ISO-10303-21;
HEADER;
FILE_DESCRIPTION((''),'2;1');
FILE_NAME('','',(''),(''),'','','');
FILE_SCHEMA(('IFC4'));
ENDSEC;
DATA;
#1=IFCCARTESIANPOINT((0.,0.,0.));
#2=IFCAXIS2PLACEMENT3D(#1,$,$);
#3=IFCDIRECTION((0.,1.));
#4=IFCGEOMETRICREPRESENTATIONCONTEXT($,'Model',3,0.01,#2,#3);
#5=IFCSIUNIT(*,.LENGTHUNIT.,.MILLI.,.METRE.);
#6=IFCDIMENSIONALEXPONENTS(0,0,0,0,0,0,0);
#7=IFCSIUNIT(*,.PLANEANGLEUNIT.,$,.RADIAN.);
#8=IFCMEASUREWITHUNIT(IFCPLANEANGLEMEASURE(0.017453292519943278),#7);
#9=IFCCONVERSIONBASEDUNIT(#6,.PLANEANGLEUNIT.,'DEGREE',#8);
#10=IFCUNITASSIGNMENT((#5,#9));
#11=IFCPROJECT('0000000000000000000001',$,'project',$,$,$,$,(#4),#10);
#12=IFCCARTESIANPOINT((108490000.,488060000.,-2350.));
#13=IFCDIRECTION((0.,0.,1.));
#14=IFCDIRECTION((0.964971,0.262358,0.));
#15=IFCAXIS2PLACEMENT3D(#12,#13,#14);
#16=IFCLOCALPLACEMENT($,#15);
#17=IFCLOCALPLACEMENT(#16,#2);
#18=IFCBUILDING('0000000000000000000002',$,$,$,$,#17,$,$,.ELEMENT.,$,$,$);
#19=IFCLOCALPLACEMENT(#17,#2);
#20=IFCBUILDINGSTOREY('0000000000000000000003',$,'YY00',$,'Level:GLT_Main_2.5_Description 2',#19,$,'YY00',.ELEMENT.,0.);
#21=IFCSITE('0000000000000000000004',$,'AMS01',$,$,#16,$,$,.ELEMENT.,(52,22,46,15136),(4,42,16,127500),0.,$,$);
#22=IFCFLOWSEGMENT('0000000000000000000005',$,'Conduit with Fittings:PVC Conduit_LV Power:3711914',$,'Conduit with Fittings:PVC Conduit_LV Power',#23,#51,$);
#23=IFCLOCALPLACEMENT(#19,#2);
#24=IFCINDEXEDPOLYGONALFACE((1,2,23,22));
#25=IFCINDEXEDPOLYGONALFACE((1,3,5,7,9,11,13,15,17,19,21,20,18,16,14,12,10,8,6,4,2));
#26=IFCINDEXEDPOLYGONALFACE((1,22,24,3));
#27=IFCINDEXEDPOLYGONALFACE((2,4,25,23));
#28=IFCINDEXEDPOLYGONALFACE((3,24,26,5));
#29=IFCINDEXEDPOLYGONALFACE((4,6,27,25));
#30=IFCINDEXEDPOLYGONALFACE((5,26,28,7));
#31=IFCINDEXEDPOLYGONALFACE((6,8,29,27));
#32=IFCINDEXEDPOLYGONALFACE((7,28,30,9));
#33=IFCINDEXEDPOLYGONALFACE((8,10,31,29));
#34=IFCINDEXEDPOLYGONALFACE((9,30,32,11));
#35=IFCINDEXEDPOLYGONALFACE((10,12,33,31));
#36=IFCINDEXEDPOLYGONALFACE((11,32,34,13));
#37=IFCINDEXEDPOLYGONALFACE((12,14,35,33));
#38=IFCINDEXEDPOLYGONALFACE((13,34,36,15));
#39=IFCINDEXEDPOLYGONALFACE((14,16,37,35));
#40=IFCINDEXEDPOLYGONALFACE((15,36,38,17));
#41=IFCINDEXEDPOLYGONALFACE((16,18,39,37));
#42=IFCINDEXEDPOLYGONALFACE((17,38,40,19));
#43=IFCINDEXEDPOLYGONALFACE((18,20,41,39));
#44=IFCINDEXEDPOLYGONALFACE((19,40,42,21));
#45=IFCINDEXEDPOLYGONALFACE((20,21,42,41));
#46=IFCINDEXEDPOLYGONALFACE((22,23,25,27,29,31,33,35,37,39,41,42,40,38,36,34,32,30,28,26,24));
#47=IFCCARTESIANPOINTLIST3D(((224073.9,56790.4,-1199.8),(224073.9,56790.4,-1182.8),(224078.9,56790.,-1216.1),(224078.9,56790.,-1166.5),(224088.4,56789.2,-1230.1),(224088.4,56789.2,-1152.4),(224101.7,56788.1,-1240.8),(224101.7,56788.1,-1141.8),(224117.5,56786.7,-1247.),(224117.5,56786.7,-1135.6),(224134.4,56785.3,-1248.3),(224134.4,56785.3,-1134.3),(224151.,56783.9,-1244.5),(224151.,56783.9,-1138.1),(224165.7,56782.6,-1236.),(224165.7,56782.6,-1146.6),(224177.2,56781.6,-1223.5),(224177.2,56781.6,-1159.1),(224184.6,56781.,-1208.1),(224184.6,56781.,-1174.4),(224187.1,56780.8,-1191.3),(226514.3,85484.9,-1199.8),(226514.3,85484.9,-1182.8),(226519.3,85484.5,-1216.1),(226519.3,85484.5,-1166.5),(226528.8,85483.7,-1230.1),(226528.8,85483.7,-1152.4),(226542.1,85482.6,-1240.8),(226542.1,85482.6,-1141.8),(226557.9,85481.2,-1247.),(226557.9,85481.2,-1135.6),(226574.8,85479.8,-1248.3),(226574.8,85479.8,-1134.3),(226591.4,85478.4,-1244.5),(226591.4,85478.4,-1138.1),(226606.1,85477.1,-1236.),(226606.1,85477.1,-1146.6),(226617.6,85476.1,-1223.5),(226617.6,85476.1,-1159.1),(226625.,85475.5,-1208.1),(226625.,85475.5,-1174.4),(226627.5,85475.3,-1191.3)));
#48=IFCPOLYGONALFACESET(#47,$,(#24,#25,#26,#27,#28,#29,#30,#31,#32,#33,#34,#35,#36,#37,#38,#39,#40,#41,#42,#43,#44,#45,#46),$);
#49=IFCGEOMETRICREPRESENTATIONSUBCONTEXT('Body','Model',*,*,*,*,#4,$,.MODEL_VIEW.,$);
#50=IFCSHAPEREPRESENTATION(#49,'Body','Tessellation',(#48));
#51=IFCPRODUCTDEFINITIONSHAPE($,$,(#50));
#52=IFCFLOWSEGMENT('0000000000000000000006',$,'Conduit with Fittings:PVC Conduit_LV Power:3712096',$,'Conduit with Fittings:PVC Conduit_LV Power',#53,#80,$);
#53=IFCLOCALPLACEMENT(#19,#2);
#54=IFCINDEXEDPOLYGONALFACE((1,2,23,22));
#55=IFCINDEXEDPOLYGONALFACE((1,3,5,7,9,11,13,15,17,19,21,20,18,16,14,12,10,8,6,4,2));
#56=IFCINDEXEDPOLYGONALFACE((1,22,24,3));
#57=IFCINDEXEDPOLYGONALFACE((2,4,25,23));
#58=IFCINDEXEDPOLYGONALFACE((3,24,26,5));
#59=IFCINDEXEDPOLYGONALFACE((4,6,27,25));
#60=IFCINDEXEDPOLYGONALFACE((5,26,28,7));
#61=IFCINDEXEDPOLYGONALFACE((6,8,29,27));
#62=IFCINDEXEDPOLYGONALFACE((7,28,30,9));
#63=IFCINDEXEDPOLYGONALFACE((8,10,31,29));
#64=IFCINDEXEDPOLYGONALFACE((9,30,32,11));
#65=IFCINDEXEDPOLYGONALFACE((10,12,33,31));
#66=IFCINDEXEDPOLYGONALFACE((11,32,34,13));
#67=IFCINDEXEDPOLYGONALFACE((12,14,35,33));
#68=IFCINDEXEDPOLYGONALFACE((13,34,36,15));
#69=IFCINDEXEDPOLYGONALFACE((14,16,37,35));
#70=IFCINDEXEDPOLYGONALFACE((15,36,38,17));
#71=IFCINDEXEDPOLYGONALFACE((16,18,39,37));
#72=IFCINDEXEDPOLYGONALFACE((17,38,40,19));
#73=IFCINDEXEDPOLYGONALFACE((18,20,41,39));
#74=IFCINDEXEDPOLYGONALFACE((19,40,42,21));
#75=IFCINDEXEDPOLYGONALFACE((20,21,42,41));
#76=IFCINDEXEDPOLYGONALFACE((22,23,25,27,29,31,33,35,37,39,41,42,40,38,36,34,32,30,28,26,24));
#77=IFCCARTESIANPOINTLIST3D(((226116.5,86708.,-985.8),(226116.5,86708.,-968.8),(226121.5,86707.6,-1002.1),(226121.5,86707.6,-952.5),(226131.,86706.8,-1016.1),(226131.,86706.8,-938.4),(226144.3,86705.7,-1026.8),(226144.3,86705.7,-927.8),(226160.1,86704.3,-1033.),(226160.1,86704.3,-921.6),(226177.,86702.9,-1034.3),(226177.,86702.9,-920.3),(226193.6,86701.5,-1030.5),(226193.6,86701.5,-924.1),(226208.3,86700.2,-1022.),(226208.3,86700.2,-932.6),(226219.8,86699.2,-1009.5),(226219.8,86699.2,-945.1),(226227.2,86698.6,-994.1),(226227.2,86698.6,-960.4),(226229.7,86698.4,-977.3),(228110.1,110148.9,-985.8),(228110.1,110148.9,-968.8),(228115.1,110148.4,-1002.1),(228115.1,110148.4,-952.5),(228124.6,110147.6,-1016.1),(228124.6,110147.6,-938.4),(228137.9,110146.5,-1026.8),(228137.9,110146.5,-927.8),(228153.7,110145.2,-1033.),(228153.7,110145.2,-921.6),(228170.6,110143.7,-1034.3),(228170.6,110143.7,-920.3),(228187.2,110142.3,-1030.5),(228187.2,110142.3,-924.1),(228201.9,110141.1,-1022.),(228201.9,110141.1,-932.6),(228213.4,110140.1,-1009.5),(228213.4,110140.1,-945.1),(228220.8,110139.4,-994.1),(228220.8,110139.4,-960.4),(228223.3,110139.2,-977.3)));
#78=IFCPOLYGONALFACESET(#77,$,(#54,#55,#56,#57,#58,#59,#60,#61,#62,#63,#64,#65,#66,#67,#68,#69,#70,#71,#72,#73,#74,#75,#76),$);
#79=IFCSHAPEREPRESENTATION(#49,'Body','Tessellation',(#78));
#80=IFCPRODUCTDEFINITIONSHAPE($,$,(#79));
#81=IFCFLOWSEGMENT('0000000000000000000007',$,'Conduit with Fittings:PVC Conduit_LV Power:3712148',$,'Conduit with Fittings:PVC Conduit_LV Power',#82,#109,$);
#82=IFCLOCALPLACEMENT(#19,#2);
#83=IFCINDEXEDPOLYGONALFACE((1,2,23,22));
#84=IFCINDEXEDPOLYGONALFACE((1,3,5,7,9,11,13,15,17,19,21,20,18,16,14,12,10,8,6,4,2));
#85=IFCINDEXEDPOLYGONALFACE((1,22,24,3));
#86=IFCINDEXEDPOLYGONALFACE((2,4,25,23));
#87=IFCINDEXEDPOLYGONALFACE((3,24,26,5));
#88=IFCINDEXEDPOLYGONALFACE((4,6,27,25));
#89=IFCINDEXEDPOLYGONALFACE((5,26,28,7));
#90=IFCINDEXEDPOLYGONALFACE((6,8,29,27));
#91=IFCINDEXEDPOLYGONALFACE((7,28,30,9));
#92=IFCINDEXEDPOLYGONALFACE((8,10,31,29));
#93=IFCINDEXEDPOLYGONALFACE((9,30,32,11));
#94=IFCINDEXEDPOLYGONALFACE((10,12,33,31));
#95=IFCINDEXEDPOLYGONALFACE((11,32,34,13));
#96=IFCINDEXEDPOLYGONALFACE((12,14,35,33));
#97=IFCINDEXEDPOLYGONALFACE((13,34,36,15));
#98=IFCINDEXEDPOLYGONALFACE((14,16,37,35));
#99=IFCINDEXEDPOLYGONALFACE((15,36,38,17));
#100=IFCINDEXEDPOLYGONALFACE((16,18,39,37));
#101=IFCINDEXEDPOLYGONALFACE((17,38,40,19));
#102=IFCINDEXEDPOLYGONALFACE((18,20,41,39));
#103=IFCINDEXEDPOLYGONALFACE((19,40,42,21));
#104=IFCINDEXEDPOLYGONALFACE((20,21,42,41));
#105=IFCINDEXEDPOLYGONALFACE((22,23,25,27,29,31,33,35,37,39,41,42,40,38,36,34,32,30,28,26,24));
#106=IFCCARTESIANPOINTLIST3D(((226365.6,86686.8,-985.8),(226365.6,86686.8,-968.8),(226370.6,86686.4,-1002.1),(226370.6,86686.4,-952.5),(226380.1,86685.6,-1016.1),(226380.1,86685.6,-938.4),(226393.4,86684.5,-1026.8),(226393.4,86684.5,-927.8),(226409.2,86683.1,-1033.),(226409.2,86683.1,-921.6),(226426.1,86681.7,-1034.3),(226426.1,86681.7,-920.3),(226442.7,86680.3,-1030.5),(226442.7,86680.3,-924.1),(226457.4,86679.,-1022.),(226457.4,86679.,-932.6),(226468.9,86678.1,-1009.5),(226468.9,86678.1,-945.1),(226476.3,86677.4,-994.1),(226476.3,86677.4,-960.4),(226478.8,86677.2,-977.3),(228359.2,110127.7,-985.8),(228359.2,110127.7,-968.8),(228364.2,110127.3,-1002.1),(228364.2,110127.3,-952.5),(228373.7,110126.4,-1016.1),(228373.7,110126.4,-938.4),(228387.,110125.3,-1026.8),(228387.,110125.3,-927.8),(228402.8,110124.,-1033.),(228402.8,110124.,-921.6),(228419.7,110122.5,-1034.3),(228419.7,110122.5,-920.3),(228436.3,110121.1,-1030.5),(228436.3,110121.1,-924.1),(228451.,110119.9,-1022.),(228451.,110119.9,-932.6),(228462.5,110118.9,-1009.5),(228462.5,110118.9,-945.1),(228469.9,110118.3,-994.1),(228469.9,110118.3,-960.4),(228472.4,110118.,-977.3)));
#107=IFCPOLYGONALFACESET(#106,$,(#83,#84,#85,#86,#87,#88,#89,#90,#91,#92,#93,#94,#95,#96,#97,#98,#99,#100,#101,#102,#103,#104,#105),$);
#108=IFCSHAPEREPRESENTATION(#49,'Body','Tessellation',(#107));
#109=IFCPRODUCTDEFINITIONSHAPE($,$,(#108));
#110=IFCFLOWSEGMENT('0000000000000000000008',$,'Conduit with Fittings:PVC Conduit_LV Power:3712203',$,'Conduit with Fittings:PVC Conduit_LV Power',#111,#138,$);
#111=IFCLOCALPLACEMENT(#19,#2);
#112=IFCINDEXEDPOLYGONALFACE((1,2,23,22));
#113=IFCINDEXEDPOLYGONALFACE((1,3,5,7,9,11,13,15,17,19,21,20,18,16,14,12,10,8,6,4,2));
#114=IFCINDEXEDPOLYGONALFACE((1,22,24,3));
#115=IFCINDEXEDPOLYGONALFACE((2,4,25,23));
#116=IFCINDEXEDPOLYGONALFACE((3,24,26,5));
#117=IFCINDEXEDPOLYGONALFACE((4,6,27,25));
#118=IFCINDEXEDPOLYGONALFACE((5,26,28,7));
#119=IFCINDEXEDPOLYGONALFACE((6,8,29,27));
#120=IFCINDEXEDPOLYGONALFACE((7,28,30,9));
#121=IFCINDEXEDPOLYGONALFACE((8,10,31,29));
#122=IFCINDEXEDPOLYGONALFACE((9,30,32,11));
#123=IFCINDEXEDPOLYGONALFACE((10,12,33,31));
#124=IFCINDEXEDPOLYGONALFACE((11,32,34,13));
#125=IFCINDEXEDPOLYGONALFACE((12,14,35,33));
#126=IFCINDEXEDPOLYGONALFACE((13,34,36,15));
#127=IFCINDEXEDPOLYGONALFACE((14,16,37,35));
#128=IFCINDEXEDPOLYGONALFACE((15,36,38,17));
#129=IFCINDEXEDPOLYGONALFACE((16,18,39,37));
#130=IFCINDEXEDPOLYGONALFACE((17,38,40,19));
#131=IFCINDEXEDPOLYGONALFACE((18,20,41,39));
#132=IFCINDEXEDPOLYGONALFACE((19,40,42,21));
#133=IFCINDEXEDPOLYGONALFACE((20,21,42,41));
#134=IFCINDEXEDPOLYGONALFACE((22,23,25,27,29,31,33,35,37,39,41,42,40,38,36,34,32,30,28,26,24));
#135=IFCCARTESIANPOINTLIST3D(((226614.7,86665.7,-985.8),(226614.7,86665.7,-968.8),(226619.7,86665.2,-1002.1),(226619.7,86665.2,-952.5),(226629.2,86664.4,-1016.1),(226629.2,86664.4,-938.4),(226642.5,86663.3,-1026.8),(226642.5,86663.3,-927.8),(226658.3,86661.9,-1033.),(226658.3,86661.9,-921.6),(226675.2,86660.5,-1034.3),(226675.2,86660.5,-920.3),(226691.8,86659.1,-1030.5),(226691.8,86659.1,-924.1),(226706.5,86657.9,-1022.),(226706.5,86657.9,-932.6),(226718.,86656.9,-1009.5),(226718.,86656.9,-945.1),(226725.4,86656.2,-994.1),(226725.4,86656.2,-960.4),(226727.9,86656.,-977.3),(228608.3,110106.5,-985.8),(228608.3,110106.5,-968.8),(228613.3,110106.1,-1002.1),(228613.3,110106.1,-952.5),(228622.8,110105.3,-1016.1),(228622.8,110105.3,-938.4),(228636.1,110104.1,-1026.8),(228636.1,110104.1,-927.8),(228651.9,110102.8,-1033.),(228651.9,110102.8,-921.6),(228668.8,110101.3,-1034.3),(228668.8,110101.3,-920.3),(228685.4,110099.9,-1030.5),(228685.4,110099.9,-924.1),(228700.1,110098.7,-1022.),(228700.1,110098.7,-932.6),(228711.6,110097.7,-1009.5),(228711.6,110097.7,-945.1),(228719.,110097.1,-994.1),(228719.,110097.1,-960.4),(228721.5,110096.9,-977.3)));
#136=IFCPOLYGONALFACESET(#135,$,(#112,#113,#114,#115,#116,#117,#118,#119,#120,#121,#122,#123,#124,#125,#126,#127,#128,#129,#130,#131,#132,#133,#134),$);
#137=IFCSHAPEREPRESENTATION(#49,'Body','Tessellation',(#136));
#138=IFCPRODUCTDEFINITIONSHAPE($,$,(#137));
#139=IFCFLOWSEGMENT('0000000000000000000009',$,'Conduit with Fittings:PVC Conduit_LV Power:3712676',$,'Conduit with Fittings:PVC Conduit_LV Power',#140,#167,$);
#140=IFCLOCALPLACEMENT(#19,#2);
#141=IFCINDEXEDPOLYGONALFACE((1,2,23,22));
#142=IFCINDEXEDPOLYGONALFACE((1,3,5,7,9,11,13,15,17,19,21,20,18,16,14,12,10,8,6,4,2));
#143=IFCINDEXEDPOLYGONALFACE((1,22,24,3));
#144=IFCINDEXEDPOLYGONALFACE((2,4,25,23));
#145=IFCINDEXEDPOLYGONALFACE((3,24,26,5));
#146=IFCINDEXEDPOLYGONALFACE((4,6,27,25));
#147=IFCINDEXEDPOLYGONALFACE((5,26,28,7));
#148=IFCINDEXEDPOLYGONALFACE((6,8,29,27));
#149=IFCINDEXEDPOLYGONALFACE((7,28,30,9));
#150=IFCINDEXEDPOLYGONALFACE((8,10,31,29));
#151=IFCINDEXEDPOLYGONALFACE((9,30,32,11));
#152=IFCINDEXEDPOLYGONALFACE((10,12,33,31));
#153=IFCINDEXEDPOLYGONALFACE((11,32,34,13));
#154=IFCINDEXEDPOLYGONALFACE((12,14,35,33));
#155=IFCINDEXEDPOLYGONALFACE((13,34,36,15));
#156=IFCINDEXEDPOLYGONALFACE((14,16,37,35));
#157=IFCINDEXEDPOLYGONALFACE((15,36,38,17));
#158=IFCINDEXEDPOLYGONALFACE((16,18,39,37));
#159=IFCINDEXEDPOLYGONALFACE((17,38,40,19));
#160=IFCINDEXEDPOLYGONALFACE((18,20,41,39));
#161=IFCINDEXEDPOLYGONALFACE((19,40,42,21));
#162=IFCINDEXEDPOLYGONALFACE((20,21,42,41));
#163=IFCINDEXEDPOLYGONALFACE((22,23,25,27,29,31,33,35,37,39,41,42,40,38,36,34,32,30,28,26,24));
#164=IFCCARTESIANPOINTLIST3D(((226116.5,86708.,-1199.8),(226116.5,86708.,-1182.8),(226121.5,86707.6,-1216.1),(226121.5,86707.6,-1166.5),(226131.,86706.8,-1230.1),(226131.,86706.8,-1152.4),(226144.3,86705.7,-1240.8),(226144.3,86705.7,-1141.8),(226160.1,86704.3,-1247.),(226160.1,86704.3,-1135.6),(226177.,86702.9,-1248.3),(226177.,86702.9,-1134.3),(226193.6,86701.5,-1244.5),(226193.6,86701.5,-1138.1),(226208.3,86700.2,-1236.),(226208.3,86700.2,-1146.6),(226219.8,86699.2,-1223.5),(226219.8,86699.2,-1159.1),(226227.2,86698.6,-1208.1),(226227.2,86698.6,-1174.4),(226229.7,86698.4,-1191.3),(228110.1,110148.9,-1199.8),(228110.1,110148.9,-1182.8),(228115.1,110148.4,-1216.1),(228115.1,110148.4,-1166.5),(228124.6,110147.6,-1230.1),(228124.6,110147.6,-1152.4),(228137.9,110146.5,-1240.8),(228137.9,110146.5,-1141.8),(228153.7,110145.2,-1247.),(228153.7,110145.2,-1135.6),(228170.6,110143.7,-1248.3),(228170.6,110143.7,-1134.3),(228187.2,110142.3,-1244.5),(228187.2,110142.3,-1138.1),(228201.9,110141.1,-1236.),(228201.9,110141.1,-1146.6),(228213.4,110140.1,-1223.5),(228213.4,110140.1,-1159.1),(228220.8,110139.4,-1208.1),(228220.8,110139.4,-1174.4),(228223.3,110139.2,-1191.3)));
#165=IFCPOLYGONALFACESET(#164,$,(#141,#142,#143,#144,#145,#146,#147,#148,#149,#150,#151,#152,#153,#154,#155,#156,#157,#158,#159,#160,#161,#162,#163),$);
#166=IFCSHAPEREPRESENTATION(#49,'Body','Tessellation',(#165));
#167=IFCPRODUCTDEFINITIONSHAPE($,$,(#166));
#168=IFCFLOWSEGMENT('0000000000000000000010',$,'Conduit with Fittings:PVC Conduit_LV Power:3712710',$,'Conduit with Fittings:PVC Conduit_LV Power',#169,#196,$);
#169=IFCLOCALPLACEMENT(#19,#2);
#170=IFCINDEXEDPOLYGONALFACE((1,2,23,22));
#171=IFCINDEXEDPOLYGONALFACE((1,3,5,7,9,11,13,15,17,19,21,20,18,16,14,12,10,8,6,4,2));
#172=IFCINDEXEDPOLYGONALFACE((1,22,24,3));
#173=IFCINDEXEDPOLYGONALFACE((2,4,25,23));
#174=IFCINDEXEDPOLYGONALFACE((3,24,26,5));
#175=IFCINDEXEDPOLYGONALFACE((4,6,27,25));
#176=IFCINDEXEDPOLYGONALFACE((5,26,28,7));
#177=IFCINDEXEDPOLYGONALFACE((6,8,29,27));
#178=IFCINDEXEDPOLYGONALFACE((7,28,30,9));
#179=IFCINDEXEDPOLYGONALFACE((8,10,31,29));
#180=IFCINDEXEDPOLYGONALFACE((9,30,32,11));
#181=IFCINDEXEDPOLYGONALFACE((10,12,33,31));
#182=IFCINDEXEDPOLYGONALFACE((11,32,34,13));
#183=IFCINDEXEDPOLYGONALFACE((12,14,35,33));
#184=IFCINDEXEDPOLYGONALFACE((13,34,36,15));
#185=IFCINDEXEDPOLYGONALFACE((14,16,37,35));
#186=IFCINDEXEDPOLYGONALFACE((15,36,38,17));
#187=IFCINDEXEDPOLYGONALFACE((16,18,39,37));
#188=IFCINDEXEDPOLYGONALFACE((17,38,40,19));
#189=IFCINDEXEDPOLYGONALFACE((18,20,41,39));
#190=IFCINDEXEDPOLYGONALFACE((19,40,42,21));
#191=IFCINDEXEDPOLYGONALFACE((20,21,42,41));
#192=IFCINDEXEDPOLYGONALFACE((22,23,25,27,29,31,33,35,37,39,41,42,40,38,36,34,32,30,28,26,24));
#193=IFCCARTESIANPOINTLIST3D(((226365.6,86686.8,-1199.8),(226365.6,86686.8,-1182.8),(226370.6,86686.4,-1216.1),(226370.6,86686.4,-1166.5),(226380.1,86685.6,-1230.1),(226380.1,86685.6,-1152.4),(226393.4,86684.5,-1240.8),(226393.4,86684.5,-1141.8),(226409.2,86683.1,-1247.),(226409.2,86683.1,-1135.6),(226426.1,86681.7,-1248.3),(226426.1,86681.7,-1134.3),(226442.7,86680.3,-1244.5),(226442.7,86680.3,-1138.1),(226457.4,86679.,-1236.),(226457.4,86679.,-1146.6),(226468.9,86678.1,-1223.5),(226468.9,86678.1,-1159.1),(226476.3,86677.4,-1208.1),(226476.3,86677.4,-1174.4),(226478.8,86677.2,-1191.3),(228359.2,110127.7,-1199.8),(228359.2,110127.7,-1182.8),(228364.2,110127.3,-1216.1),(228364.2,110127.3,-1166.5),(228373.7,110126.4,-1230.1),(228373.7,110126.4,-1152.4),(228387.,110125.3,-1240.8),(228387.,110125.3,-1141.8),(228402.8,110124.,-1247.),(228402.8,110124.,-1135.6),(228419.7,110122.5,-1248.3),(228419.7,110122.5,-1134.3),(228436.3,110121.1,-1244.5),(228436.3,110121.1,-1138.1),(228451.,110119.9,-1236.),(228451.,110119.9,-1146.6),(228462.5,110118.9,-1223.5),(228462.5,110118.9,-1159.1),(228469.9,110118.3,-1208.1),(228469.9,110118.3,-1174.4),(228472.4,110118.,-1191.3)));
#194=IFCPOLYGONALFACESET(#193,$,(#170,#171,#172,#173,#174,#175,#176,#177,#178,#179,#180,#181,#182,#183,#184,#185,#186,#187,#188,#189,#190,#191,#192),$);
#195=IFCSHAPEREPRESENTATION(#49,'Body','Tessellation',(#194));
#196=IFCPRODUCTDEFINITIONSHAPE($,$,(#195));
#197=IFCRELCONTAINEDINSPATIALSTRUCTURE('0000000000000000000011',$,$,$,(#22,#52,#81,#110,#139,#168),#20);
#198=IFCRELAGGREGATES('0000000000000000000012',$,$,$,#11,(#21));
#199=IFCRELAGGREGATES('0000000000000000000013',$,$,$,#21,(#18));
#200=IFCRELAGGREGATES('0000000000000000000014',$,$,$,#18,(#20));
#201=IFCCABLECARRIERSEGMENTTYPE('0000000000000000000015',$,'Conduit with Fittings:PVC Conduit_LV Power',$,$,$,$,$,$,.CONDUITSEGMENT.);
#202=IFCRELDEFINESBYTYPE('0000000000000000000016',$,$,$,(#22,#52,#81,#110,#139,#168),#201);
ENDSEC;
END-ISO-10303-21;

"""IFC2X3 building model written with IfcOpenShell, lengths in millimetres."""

from ifc_helpers import new_model, entity, si_unit, converted_unit, direction, frame, frame_2d, origin, origin_2d_with_axis, place, context, subcontext, project, spatial, circle, extrude, type_object, element, save


model = new_model("IFC2X3")

# Units and contexts
model_context = context("Model", 3, precision=0.01, world=origin(), true_north=direction((0.0, 1.0)))
body_context = subcontext(model_context, "Body", "Model", "MODEL_VIEW")
ifc_project = project(units=[si_unit("LENGTHUNIT", "METRE", prefix="MILLI"), converted_unit("PLANEANGLEUNIT", "DEGREE", entity("IfcPlaneAngleMeasure", 0.017453292519943278), si_unit("PLANEANGLEUNIT", "RADIAN"), dimensions=[0, 0, 0, 0, 0, 0, 0])], contexts=[model_context])

# Site, building, storey
site_placement = place(None, frame((108490000.0, 488060000.0, -2350.0), z_axis=(0.0, 0.0, 1.0), x_axis=(0.964971, 0.262358, 0.0)))
site = spatial("IfcSite", under=ifc_project, at=site_placement, Name="AMS01", CompositionType="ELEMENT", RefLatitude=(52, 22, 46, 15136), RefLongitude=(4, 42, 16, 127500), RefElevation=0.0)
building_placement = place(site_placement, origin())
building = spatial("IfcBuilding", under=site, at=building_placement, CompositionType="ELEMENT")
storey_placement = place(building_placement, origin())
storey = spatial("IfcBuildingStorey", under=building, at=storey_placement, Name="YY00", ObjectType="Level:GLT_Main_2.5_Description 2", LongName="YY00", CompositionType="ELEMENT", Elevation=0.0)

# Flow segments
cable_carrier_segment_type = type_object("IfcCableCarrierSegmentType", Name="Conduit with Fittings:PVC Conduit_LV Power", PredefinedType="CONDUITSEGMENT")
flow_segment_1_placement = place(storey_placement, origin())
element("IfcFlowSegment", 1, at=flow_segment_1_placement, inside=storey, type_object=cable_carrier_segment_type, Name="Conduit with Fittings:PVC Conduit_LV Power:3711914", ObjectType="Conduit with Fittings:PVC Conduit_LV Power", context=body_context, shape_type="SweptSolid", body=[
    extrude(circle(Radius=57.2, at=origin_2d_with_axis()), frame((224130.2, 56785.6, -1191.3), z_axis=(0.084742, 0.996403, 0.0), x_axis=(0.996403, -0.084742, 0.0)), (0.0, 0.0, 1.0), 28798.1),
])
flow_segment_2_placement = place(storey_placement, origin())
element("IfcFlowSegment", 2, at=flow_segment_2_placement, inside=storey, type_object=cable_carrier_segment_type, Name="Conduit with Fittings:PVC Conduit_LV Power:3712096", ObjectType="Conduit with Fittings:PVC Conduit_LV Power", context=body_context, shape_type="SweptSolid", body=[
    extrude(circle(Radius=57.2, at=origin_2d_with_axis()), frame((226172.8, 86703.2, -977.3), z_axis=(0.084742, 0.996403, 0.0), x_axis=(0.996403, -0.084742, 0.0)), (0.0, 0.0, 1.0), 23525.5),
])
flow_segment_3_placement = place(storey_placement, origin())
element("IfcFlowSegment", 3, at=flow_segment_3_placement, inside=storey, type_object=cable_carrier_segment_type, Name="Conduit with Fittings:PVC Conduit_LV Power:3712148", ObjectType="Conduit with Fittings:PVC Conduit_LV Power", context=body_context, shape_type="SweptSolid", body=[
    extrude(circle(Radius=57.2, at=origin_2d_with_axis()), frame((226421.9, 86682.1, -977.3), z_axis=(0.084742, 0.996403, 0.0), x_axis=(0.996403, -0.084742, 0.0)), (0.0, 0.0, 1.0), 23525.5),
])
flow_segment_4_placement = place(storey_placement, origin())
element("IfcFlowSegment", 4, at=flow_segment_4_placement, inside=storey, type_object=cable_carrier_segment_type, Name="Conduit with Fittings:PVC Conduit_LV Power:3712203", ObjectType="Conduit with Fittings:PVC Conduit_LV Power", context=body_context, shape_type="SweptSolid", body=[
    extrude(circle(Radius=57.2, at=origin_2d_with_axis()), frame((226671.0, 86660.9, -977.3), z_axis=(0.084742, 0.996403, 0.0), x_axis=(0.996403, -0.084742, 0.0)), (0.0, 0.0, 1.0), 23525.5),
])
flow_segment_5_placement = place(storey_placement, origin())
element("IfcFlowSegment", 5, at=flow_segment_5_placement, inside=storey, type_object=cable_carrier_segment_type, Name="Conduit with Fittings:PVC Conduit_LV Power:3712676", ObjectType="Conduit with Fittings:PVC Conduit_LV Power", context=body_context, shape_type="SweptSolid", body=[
    extrude(circle(Radius=57.2, at=origin_2d_with_axis()), frame((226172.8, 86703.2, -1191.3), z_axis=(0.084742, 0.996403, 0.0), x_axis=(0.996403, -0.084742, 0.0)), (0.0, 0.0, 1.0), 23525.5),
])
flow_segment_6_placement = place(storey_placement, origin())
element("IfcFlowSegment", 6, at=flow_segment_6_placement, inside=storey, type_object=cable_carrier_segment_type, Name="Conduit with Fittings:PVC Conduit_LV Power:3712710", ObjectType="Conduit with Fittings:PVC Conduit_LV Power", context=body_context, shape_type="SweptSolid", body=[
    extrude(circle(Radius=57.2, at=frame_2d((0.0, 0.0), x_axis=(1.0, 0.0))), frame((226421.9, 86682.1, -1191.3), z_axis=(0.084742, 0.996403, 0.0), x_axis=(0.996403, -0.084742, 0.0)), (0.0, 0.0, 1.0), 23525.5),
])

save(model, "model.ifc")
